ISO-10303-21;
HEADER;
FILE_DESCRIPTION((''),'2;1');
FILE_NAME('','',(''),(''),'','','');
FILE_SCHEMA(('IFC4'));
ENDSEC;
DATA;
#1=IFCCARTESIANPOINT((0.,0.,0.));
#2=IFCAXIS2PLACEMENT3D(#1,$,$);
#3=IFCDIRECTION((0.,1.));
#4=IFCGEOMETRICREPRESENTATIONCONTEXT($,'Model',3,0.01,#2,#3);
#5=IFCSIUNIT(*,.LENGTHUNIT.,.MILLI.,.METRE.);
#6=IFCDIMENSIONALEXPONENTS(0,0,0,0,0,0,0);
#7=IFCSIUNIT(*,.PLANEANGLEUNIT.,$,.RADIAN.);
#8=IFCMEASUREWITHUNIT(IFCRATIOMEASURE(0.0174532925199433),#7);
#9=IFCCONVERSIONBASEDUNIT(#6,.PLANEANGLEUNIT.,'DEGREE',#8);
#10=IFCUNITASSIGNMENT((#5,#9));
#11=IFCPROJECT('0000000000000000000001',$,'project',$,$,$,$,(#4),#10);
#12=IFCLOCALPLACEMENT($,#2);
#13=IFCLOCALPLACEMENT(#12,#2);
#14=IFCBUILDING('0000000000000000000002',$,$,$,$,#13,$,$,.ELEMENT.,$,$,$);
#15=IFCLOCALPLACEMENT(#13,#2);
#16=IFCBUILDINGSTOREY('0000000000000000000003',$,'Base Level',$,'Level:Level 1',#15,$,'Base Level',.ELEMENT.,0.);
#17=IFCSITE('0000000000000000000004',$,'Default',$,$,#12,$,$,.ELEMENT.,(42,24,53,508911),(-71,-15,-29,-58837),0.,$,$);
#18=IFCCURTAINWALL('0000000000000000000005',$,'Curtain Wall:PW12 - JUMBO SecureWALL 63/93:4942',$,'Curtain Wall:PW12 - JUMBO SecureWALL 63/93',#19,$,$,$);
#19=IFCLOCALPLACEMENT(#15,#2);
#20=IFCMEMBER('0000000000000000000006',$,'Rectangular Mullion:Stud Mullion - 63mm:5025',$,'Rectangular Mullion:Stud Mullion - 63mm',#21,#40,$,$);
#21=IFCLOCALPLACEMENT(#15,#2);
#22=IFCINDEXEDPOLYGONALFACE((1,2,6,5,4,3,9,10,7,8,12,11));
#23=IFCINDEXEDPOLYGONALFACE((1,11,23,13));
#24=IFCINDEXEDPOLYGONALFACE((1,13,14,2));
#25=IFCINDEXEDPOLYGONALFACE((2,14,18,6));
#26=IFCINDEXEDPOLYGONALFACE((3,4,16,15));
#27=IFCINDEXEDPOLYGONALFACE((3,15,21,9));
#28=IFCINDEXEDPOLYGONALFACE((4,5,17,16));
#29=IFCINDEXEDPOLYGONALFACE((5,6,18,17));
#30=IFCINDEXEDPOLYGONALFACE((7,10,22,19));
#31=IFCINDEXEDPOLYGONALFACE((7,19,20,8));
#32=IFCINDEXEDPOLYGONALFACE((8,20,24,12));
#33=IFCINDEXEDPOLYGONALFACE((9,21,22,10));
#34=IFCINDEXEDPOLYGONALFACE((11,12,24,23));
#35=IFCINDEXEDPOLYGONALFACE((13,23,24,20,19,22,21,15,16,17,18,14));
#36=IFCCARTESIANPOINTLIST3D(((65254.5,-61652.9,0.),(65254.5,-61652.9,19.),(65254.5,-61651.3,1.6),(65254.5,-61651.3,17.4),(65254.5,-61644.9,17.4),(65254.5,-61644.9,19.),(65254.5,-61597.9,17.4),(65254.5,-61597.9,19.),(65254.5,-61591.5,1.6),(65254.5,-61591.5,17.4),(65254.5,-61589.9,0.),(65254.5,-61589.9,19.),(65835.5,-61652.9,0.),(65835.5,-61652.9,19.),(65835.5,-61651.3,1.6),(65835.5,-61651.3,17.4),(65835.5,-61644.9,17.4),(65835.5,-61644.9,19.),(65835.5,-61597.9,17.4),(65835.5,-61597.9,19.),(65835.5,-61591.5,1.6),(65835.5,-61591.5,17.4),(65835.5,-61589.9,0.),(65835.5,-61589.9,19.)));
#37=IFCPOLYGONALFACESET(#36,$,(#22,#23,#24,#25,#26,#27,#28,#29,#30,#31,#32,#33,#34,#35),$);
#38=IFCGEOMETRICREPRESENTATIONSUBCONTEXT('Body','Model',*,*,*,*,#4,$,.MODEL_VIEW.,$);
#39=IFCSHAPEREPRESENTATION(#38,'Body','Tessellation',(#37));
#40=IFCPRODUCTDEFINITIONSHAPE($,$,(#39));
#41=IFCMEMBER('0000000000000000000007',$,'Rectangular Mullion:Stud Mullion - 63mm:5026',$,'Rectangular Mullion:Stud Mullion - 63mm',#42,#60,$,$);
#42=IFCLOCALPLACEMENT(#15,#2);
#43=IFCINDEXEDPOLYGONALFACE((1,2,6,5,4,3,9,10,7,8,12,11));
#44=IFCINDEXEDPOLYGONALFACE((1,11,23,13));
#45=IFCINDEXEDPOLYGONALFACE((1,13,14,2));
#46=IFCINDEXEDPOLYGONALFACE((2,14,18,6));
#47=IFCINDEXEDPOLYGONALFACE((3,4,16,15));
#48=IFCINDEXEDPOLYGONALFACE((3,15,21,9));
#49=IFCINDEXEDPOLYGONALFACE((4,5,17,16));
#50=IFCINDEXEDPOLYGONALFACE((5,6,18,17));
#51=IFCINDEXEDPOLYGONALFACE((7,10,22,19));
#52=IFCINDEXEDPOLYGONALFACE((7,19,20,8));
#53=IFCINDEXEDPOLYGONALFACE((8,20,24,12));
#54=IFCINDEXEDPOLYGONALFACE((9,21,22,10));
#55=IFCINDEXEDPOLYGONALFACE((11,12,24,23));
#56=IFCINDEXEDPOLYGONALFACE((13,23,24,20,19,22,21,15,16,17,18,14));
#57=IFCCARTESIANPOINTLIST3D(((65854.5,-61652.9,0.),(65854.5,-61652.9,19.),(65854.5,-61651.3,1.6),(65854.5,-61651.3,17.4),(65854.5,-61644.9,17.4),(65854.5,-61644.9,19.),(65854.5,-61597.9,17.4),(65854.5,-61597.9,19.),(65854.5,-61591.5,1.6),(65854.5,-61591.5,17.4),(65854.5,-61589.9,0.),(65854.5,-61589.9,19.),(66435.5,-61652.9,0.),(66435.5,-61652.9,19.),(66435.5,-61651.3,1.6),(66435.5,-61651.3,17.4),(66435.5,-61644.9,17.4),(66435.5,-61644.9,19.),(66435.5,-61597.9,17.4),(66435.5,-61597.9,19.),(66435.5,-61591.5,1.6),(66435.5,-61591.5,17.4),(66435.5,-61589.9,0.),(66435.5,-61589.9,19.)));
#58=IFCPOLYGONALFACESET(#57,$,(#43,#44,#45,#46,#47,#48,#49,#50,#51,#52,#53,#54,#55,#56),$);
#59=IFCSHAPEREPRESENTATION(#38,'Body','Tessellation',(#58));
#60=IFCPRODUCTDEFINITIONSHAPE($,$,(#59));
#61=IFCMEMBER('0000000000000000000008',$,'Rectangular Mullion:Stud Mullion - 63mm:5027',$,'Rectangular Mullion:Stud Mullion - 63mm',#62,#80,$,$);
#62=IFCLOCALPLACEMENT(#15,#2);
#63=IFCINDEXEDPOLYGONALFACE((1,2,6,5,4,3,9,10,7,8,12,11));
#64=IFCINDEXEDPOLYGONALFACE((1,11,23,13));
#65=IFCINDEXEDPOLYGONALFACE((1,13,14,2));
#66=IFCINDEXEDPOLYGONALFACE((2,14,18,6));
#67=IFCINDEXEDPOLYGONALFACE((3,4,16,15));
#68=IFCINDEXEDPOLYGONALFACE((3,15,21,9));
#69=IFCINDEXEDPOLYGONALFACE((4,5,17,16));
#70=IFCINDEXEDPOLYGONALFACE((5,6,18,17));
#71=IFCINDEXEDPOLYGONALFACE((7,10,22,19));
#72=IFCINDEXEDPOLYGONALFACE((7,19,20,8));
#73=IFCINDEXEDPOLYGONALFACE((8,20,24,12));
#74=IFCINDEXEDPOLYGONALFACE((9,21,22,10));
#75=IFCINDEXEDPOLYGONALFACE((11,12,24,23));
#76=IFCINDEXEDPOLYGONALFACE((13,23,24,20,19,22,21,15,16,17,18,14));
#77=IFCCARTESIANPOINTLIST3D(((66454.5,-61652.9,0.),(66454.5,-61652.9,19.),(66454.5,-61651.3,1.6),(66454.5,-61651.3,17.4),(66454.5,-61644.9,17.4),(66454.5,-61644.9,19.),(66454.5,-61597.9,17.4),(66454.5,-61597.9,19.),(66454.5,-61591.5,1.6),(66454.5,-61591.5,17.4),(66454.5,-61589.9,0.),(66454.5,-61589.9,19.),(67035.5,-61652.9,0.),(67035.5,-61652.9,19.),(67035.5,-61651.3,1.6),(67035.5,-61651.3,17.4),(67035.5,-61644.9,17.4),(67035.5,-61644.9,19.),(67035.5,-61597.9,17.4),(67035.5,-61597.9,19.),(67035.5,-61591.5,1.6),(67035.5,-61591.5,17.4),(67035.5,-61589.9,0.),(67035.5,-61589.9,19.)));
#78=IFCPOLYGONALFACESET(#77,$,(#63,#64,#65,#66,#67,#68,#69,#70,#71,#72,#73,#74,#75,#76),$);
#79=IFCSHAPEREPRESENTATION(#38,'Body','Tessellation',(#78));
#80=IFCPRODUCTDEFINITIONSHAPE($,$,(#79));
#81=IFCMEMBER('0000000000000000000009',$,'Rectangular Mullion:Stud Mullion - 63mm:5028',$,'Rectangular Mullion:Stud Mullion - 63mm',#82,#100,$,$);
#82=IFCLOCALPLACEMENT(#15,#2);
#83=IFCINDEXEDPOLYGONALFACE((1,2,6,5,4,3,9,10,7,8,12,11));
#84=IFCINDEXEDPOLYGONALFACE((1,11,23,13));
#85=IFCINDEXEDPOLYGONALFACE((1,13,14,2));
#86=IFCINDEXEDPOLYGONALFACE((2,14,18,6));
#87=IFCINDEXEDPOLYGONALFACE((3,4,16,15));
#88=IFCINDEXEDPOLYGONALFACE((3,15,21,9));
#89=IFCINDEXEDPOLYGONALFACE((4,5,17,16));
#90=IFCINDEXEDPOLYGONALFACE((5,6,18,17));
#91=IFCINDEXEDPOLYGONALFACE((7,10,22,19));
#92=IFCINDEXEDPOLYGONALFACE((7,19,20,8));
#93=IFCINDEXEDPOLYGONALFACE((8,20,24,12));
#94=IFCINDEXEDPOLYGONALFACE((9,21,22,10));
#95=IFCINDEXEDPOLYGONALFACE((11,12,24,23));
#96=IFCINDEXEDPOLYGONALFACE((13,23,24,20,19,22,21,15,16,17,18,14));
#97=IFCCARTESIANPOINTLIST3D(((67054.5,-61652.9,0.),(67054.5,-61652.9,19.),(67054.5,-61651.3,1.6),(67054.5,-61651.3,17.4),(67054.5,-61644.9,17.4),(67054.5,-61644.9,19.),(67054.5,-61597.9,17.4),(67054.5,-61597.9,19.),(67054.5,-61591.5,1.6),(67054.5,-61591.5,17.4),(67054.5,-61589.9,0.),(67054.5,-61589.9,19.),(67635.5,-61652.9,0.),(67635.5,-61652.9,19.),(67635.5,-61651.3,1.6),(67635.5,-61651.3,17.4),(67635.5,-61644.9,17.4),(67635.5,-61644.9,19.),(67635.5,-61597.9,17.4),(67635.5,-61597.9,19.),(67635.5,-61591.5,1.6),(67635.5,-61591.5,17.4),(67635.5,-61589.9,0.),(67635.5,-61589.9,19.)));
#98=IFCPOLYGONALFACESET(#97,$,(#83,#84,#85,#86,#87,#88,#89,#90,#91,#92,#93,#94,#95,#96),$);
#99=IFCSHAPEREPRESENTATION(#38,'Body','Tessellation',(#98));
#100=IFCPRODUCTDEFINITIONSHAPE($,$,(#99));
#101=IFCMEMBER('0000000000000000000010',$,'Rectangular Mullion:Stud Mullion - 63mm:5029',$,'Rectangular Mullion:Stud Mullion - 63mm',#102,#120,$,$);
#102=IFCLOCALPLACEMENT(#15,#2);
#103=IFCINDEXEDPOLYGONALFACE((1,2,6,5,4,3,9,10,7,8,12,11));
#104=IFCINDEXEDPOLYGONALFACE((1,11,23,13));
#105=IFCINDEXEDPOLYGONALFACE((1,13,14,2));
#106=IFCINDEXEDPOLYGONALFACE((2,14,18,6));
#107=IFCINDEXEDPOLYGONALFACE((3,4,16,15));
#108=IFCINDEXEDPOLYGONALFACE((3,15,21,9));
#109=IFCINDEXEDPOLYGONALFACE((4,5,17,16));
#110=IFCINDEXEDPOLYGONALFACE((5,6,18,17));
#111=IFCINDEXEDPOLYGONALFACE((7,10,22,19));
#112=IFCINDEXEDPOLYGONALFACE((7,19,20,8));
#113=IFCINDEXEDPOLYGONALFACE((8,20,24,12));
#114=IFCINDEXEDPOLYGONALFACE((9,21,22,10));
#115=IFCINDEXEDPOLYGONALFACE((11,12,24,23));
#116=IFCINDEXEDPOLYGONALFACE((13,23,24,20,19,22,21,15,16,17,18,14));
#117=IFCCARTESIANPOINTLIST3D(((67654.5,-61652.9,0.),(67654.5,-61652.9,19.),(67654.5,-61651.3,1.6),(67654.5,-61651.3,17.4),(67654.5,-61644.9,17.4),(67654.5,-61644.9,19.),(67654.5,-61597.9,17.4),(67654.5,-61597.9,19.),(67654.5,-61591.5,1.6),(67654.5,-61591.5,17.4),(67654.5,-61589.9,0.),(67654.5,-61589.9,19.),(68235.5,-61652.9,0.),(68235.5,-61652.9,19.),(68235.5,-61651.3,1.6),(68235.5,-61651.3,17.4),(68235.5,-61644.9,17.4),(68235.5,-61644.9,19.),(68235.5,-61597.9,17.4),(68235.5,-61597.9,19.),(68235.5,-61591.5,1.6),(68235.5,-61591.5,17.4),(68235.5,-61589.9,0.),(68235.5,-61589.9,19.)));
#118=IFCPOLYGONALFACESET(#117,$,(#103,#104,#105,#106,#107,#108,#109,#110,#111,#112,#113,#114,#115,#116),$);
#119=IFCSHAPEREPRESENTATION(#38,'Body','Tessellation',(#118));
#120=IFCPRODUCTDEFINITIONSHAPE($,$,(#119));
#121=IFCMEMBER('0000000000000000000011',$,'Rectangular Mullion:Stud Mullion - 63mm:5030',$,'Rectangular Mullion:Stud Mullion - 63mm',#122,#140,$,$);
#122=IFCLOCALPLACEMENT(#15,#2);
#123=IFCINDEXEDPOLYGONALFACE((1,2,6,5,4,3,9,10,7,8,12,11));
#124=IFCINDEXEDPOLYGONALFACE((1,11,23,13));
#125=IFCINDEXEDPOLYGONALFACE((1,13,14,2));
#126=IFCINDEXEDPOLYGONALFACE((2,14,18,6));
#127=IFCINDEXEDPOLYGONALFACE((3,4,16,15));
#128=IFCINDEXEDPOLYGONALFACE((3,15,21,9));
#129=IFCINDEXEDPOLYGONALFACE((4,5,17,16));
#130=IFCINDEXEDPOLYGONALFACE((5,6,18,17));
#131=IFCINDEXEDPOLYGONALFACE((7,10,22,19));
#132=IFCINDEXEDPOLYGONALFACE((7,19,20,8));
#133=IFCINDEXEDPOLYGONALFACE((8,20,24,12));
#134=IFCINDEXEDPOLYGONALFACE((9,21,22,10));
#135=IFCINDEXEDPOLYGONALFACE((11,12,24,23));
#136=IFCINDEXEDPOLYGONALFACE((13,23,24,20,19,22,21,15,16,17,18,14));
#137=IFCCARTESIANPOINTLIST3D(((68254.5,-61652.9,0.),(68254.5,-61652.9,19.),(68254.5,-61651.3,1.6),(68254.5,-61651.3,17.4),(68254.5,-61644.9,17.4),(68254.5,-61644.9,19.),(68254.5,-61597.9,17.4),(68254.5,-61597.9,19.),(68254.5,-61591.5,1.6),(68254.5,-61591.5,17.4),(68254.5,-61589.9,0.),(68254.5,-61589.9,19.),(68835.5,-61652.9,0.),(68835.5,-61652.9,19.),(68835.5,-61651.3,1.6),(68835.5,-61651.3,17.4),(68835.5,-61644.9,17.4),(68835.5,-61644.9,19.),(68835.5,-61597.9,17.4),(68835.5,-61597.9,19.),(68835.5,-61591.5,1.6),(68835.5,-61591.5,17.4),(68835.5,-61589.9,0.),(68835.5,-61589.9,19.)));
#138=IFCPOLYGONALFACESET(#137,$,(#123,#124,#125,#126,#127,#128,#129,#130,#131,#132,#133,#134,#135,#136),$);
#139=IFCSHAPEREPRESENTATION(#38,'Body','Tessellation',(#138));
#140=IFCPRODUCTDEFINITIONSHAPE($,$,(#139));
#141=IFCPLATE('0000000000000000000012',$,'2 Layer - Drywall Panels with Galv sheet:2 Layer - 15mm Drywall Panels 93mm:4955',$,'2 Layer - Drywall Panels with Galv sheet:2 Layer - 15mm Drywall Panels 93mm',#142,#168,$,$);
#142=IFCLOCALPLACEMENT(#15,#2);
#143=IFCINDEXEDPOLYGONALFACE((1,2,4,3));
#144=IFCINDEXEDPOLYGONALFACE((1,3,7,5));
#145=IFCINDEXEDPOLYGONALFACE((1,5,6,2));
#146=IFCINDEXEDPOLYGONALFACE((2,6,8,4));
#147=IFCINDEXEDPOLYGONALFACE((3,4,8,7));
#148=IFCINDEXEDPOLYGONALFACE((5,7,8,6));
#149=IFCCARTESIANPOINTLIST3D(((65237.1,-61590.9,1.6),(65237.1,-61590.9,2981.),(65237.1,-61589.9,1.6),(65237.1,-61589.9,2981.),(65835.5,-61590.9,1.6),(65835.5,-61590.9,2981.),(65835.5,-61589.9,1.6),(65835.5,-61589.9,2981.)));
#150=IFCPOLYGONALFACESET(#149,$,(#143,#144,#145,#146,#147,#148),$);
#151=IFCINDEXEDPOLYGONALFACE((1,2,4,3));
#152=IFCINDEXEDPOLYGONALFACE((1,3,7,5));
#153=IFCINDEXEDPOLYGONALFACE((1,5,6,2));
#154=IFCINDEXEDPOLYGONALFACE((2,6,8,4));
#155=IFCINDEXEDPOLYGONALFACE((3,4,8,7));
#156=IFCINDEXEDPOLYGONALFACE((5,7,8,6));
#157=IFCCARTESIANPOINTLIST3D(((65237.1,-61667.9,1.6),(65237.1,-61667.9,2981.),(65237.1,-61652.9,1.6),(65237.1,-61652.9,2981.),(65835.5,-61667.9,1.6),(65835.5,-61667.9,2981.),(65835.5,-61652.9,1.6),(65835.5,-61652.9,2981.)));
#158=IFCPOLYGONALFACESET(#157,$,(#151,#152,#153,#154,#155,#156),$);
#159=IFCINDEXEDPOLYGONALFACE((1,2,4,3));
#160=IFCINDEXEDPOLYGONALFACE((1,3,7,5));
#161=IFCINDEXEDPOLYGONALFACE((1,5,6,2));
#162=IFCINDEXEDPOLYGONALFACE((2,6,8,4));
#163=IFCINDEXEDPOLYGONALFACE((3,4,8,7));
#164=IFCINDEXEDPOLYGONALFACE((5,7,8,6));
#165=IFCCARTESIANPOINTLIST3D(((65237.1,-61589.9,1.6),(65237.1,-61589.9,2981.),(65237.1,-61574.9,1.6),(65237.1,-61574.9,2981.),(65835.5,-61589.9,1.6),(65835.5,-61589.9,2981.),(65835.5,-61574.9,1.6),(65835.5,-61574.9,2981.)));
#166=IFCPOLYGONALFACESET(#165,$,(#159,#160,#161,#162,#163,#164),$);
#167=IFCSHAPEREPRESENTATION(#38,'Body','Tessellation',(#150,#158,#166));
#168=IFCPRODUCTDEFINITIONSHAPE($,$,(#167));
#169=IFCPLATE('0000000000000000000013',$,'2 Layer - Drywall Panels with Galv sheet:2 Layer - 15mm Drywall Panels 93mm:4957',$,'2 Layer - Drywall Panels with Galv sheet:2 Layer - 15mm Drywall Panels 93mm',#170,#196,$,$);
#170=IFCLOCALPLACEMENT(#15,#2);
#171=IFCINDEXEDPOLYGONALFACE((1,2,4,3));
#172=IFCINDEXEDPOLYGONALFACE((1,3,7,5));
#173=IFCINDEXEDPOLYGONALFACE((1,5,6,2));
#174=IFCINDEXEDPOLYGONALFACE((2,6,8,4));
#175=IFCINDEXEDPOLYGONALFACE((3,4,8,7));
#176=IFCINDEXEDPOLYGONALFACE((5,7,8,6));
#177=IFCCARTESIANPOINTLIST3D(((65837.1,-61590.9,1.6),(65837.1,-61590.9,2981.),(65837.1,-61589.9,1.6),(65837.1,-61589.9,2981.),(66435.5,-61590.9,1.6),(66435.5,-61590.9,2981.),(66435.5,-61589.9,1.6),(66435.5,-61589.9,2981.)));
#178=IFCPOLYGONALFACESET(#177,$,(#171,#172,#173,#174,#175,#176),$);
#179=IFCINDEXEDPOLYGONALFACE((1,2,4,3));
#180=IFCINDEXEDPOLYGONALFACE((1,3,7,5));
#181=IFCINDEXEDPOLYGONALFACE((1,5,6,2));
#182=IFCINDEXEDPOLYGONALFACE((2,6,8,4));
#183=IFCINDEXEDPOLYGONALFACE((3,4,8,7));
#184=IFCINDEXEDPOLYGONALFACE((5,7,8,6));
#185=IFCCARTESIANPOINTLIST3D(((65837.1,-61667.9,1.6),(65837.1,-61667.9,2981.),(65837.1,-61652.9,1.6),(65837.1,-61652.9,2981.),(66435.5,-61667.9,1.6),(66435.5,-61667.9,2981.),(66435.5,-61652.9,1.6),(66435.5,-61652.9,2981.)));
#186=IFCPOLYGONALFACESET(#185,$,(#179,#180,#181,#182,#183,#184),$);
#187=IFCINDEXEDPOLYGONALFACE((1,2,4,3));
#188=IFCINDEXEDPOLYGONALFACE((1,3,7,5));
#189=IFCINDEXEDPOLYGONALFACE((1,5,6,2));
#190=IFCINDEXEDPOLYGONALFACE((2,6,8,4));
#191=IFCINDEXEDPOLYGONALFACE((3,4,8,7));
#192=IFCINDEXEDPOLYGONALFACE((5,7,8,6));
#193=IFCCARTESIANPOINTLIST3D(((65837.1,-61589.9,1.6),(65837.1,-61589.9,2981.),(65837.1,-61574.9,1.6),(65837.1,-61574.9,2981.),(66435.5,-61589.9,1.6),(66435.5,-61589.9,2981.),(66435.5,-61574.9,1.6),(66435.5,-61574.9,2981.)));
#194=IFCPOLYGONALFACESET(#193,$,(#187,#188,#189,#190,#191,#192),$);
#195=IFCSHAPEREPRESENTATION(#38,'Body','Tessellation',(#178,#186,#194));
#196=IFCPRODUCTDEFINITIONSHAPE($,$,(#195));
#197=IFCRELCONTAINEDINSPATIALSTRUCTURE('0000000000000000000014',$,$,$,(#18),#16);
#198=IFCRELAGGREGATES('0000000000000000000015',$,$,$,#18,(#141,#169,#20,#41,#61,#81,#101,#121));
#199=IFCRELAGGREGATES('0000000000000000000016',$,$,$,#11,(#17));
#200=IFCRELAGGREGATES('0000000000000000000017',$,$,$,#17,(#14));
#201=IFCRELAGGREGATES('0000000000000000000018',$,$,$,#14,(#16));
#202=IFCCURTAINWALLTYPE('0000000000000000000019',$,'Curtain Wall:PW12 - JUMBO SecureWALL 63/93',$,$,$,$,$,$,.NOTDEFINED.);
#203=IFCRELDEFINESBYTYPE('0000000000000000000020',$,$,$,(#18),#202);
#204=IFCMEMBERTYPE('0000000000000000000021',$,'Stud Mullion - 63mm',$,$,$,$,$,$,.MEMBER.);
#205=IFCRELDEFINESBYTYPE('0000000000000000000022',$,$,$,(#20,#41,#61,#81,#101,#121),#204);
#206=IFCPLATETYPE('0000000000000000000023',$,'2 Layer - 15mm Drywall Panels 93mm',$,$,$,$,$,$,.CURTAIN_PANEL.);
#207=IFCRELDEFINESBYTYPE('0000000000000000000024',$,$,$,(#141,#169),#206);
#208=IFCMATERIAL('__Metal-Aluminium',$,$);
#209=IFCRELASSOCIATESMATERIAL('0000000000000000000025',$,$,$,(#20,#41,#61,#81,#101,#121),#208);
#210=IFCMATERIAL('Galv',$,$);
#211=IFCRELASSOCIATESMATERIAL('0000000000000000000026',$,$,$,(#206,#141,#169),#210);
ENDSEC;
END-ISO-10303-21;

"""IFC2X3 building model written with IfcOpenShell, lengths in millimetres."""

from ifc_helpers import new_model, entity, si_unit, converted_unit, direction, frame, frame_2d, origin, origin_2d_with_axis, place, context, subcontext, project, spatial, polyline, rectangle, outline, extrude, source, transform, mapped, material, type_object, type_shapes, element, aggregate, save


model = new_model("IFC2X3")

# Units and contexts
model_context = context("Model", 3, precision=0.01, world=origin(), true_north=direction((0.0, 1.0)))
body_context = subcontext(model_context, "Body", "Model", "MODEL_VIEW")
ifc_project = project(units=[si_unit("LENGTHUNIT", "METRE", prefix="MILLI"), converted_unit("PLANEANGLEUNIT", "DEGREE", entity("IfcRatioMeasure", 0.0174532925199433), si_unit("PLANEANGLEUNIT", "RADIAN"), dimensions=[0, 0, 0, 0, 0, 0, 0])], contexts=[model_context])

# Site, building, storey
site_placement = place(None, origin())
site = spatial("IfcSite", under=ifc_project, at=site_placement, Name="Default", CompositionType="ELEMENT", RefLatitude=(42, 24, 53, 508911), RefLongitude=(-71, -15, -29, -58837), RefElevation=0.0)
building_placement = place(site_placement, origin())
building = spatial("IfcBuilding", under=site, at=building_placement, CompositionType="ELEMENT")
storey_placement = place(building_placement, origin())
storey = spatial("IfcBuildingStorey", under=building, at=storey_placement, Name="Base Level", ObjectType="Level:Level 1", LongName="Base Level", CompositionType="ELEMENT", Elevation=0.0)

# Curtain wall, members, plates
curtain_wall_type = type_object("IfcCurtainWallType", Name="Curtain Wall:PW12 - JUMBO SecureWALL 63/93", PredefinedType="NOTDEFINED")
curtain_wall_placement = place(building_placement, origin())
curtain_wall = element("IfcCurtainWall", 1, at=curtain_wall_placement, inside=storey, type_object=curtain_wall_type, Name="Curtain Wall:PW12 - JUMBO SecureWALL 63/93:4942", ObjectType="Curtain Wall:PW12 - JUMBO SecureWALL 63/93")
ifc_material_1 = material(Name="__Metal-Aluminium")
member_type_1 = type_object("IfcMemberType", Name="Stud Mullion - 63mm", PredefinedType="MEMBER")
shared_shape_1 = source(origin(), body_context, "Body", "SweptSolid", [
    extrude(outline(polyline([(23.5, -6.6), (31.5, -6.6), (31.5, 12.4), (-31.5, 12.4), (-31.5, -6.6), (-23.5, -6.6), (-23.5, -5.0), (-29.9, -5.0), (-29.9, 10.8), (29.9, 10.8), (29.9, -5.0), (23.5, -5.0), (23.5, -6.6)])), frame((-12.4, 0.0, -581.0), z_axis=(0.0, 0.0, 1.0), x_axis=(0.0, -1.0, 0.0)), (0.0, 0.0, 1.0), 581.0),
])
type_shapes(member_type_1, [shared_shape_1])
member_1_placement = place(building_placement, frame((65254.5, -61621.4, 0.0), z_axis=(-1.0, 0.0, 0.0), x_axis=(0.0, 0.0, -1.0)))
member_1 = element("IfcMember", 2, at=member_1_placement, type_object=member_type_1, material=ifc_material_1, Name="Rectangular Mullion:Stud Mullion - 63mm:5025", ObjectType="Rectangular Mullion:Stud Mullion - 63mm", context=body_context, shape_type="MappedRepresentation", body=[
    mapped(shared_shape_1, transform((0.0, 0.0, 0.0), scale=1.0)),
])
member_2_placement = place(building_placement, frame((65854.5, -61621.4, 0.0), z_axis=(-1.0, 0.0, 0.0), x_axis=(0.0, 0.0, -1.0)))
member_2 = element("IfcMember", 3, at=member_2_placement, type_object=member_type_1, material=ifc_material_1, Name="Rectangular Mullion:Stud Mullion - 63mm:5026", ObjectType="Rectangular Mullion:Stud Mullion - 63mm", context=body_context, shape_type="MappedRepresentation", body=[
    mapped(shared_shape_1, transform((0.0, 0.0, 0.0), scale=1.0)),
])
member_3_placement = place(building_placement, frame((66454.5, -61621.4, 0.0), z_axis=(-1.0, 0.0, 0.0), x_axis=(0.0, 0.0, -1.0)))
member_3 = element("IfcMember", 4, at=member_3_placement, type_object=member_type_1, material=ifc_material_1, Name="Rectangular Mullion:Stud Mullion - 63mm:5027", ObjectType="Rectangular Mullion:Stud Mullion - 63mm", context=body_context, shape_type="MappedRepresentation", body=[
    mapped(shared_shape_1, transform((0.0, 0.0, 0.0), scale=1.0)),
])
member_4_placement = place(building_placement, frame((67054.5, -61621.4, 0.0), z_axis=(-1.0, 0.0, 0.0), x_axis=(0.0, 0.0, -1.0)))
member_4 = element("IfcMember", 5, at=member_4_placement, type_object=member_type_1, material=ifc_material_1, Name="Rectangular Mullion:Stud Mullion - 63mm:5028", ObjectType="Rectangular Mullion:Stud Mullion - 63mm", context=body_context, shape_type="MappedRepresentation", body=[
    mapped(shared_shape_1, transform((0.0, 0.0, 0.0), scale=1.0)),
])
member_5_placement = place(building_placement, frame((67654.5, -61621.4, 0.0), z_axis=(-1.0, 0.0, 0.0), x_axis=(0.0, 0.0, -1.0)))
member_5 = element("IfcMember", 6, at=member_5_placement, type_object=member_type_1, material=ifc_material_1, Name="Rectangular Mullion:Stud Mullion - 63mm:5029", ObjectType="Rectangular Mullion:Stud Mullion - 63mm", context=body_context, shape_type="MappedRepresentation", body=[
    mapped(shared_shape_1, transform((0.0, 0.0, 0.0), scale=1.0)),
])
member_6_placement = place(building_placement, frame((68254.5, -61621.4, 0.0), z_axis=(-1.0, 0.0, 0.0), x_axis=(0.0, 0.0, -1.0)))
member_6 = element("IfcMember", 7, at=member_6_placement, type_object=member_type_1, material=ifc_material_1, Name="Rectangular Mullion:Stud Mullion - 63mm:5030", ObjectType="Rectangular Mullion:Stud Mullion - 63mm", context=body_context, shape_type="MappedRepresentation", body=[
    mapped(shared_shape_1, transform((0.0, 0.0, 0.0), scale=1.0)),
])
ifc_material_2 = material(Name="Galv")
plate_type = type_object("IfcPlateType", Name="2 Layer - 15mm Drywall Panels 93mm", PredefinedType="CURTAIN_PANEL", material=ifc_material_2)
shared_shape_2 = source(origin(), body_context, "Body", "SweptSolid", [
    extrude(rectangle(XDim=598.4, YDim=1.0, at=origin_2d_with_axis()), frame((0.0, 31.0, 0.0), z_axis=(0.0, 0.0, 1.0), x_axis=(-1.0, 0.0, 0.0)), (0.0, 0.0, 1.0), 2979.4),
    extrude(rectangle(XDim=598.4, YDim=15.0, at=frame_2d((0.0, 0.0), x_axis=(1.0, 0.0))), frame((0.0, -39.0, 0.0), z_axis=(0.0, 0.0, 1.0), x_axis=(-1.0, 0.0, 0.0)), (0.0, 0.0, 1.0), 2979.4),
    extrude(rectangle(XDim=15.0, YDim=598.4, at=frame_2d((0.0, 0.0), x_axis=(1.0, 0.0))), frame((0.0, 39.0, 0.0), z_axis=(0.0, 0.0, 1.0), x_axis=(0.0, 1.0, 0.0)), (0.0, 0.0, 1.0), 2979.4),
])
type_shapes(plate_type, [shared_shape_2])
plate_1_placement = place(curtain_wall_placement, frame((65536.3, -61621.4, 1.6)))
plate_1 = element("IfcPlate", 8, at=plate_1_placement, type_object=plate_type, material=ifc_material_2, Name="2 Layer - Drywall Panels with Galv sheet:2 Layer - 15mm Drywall Panels 93mm:4955", ObjectType="2 Layer - Drywall Panels with Galv sheet:2 Layer - 15mm Drywall Panels 93mm", context=body_context, shape_type="MappedRepresentation", body=[
    mapped(shared_shape_2, transform((0.0, 0.0, 0.0), scale=1.0)),
])
plate_2_placement = place(curtain_wall_placement, frame((66136.3, -61621.4, 1.6)))
plate_2 = element("IfcPlate", 9, at=plate_2_placement, type_object=plate_type, material=ifc_material_2, Name="2 Layer - Drywall Panels with Galv sheet:2 Layer - 15mm Drywall Panels 93mm:4957", ObjectType="2 Layer - Drywall Panels with Galv sheet:2 Layer - 15mm Drywall Panels 93mm", context=body_context, shape_type="MappedRepresentation", body=[
    mapped(shared_shape_2, transform((0.0, 0.0, 0.0), scale=1.0)),
])
aggregate(curtain_wall, [plate_1, plate_2, member_1, member_2, member_3, member_4, member_5, member_6])

save(model, "model.ifc")
